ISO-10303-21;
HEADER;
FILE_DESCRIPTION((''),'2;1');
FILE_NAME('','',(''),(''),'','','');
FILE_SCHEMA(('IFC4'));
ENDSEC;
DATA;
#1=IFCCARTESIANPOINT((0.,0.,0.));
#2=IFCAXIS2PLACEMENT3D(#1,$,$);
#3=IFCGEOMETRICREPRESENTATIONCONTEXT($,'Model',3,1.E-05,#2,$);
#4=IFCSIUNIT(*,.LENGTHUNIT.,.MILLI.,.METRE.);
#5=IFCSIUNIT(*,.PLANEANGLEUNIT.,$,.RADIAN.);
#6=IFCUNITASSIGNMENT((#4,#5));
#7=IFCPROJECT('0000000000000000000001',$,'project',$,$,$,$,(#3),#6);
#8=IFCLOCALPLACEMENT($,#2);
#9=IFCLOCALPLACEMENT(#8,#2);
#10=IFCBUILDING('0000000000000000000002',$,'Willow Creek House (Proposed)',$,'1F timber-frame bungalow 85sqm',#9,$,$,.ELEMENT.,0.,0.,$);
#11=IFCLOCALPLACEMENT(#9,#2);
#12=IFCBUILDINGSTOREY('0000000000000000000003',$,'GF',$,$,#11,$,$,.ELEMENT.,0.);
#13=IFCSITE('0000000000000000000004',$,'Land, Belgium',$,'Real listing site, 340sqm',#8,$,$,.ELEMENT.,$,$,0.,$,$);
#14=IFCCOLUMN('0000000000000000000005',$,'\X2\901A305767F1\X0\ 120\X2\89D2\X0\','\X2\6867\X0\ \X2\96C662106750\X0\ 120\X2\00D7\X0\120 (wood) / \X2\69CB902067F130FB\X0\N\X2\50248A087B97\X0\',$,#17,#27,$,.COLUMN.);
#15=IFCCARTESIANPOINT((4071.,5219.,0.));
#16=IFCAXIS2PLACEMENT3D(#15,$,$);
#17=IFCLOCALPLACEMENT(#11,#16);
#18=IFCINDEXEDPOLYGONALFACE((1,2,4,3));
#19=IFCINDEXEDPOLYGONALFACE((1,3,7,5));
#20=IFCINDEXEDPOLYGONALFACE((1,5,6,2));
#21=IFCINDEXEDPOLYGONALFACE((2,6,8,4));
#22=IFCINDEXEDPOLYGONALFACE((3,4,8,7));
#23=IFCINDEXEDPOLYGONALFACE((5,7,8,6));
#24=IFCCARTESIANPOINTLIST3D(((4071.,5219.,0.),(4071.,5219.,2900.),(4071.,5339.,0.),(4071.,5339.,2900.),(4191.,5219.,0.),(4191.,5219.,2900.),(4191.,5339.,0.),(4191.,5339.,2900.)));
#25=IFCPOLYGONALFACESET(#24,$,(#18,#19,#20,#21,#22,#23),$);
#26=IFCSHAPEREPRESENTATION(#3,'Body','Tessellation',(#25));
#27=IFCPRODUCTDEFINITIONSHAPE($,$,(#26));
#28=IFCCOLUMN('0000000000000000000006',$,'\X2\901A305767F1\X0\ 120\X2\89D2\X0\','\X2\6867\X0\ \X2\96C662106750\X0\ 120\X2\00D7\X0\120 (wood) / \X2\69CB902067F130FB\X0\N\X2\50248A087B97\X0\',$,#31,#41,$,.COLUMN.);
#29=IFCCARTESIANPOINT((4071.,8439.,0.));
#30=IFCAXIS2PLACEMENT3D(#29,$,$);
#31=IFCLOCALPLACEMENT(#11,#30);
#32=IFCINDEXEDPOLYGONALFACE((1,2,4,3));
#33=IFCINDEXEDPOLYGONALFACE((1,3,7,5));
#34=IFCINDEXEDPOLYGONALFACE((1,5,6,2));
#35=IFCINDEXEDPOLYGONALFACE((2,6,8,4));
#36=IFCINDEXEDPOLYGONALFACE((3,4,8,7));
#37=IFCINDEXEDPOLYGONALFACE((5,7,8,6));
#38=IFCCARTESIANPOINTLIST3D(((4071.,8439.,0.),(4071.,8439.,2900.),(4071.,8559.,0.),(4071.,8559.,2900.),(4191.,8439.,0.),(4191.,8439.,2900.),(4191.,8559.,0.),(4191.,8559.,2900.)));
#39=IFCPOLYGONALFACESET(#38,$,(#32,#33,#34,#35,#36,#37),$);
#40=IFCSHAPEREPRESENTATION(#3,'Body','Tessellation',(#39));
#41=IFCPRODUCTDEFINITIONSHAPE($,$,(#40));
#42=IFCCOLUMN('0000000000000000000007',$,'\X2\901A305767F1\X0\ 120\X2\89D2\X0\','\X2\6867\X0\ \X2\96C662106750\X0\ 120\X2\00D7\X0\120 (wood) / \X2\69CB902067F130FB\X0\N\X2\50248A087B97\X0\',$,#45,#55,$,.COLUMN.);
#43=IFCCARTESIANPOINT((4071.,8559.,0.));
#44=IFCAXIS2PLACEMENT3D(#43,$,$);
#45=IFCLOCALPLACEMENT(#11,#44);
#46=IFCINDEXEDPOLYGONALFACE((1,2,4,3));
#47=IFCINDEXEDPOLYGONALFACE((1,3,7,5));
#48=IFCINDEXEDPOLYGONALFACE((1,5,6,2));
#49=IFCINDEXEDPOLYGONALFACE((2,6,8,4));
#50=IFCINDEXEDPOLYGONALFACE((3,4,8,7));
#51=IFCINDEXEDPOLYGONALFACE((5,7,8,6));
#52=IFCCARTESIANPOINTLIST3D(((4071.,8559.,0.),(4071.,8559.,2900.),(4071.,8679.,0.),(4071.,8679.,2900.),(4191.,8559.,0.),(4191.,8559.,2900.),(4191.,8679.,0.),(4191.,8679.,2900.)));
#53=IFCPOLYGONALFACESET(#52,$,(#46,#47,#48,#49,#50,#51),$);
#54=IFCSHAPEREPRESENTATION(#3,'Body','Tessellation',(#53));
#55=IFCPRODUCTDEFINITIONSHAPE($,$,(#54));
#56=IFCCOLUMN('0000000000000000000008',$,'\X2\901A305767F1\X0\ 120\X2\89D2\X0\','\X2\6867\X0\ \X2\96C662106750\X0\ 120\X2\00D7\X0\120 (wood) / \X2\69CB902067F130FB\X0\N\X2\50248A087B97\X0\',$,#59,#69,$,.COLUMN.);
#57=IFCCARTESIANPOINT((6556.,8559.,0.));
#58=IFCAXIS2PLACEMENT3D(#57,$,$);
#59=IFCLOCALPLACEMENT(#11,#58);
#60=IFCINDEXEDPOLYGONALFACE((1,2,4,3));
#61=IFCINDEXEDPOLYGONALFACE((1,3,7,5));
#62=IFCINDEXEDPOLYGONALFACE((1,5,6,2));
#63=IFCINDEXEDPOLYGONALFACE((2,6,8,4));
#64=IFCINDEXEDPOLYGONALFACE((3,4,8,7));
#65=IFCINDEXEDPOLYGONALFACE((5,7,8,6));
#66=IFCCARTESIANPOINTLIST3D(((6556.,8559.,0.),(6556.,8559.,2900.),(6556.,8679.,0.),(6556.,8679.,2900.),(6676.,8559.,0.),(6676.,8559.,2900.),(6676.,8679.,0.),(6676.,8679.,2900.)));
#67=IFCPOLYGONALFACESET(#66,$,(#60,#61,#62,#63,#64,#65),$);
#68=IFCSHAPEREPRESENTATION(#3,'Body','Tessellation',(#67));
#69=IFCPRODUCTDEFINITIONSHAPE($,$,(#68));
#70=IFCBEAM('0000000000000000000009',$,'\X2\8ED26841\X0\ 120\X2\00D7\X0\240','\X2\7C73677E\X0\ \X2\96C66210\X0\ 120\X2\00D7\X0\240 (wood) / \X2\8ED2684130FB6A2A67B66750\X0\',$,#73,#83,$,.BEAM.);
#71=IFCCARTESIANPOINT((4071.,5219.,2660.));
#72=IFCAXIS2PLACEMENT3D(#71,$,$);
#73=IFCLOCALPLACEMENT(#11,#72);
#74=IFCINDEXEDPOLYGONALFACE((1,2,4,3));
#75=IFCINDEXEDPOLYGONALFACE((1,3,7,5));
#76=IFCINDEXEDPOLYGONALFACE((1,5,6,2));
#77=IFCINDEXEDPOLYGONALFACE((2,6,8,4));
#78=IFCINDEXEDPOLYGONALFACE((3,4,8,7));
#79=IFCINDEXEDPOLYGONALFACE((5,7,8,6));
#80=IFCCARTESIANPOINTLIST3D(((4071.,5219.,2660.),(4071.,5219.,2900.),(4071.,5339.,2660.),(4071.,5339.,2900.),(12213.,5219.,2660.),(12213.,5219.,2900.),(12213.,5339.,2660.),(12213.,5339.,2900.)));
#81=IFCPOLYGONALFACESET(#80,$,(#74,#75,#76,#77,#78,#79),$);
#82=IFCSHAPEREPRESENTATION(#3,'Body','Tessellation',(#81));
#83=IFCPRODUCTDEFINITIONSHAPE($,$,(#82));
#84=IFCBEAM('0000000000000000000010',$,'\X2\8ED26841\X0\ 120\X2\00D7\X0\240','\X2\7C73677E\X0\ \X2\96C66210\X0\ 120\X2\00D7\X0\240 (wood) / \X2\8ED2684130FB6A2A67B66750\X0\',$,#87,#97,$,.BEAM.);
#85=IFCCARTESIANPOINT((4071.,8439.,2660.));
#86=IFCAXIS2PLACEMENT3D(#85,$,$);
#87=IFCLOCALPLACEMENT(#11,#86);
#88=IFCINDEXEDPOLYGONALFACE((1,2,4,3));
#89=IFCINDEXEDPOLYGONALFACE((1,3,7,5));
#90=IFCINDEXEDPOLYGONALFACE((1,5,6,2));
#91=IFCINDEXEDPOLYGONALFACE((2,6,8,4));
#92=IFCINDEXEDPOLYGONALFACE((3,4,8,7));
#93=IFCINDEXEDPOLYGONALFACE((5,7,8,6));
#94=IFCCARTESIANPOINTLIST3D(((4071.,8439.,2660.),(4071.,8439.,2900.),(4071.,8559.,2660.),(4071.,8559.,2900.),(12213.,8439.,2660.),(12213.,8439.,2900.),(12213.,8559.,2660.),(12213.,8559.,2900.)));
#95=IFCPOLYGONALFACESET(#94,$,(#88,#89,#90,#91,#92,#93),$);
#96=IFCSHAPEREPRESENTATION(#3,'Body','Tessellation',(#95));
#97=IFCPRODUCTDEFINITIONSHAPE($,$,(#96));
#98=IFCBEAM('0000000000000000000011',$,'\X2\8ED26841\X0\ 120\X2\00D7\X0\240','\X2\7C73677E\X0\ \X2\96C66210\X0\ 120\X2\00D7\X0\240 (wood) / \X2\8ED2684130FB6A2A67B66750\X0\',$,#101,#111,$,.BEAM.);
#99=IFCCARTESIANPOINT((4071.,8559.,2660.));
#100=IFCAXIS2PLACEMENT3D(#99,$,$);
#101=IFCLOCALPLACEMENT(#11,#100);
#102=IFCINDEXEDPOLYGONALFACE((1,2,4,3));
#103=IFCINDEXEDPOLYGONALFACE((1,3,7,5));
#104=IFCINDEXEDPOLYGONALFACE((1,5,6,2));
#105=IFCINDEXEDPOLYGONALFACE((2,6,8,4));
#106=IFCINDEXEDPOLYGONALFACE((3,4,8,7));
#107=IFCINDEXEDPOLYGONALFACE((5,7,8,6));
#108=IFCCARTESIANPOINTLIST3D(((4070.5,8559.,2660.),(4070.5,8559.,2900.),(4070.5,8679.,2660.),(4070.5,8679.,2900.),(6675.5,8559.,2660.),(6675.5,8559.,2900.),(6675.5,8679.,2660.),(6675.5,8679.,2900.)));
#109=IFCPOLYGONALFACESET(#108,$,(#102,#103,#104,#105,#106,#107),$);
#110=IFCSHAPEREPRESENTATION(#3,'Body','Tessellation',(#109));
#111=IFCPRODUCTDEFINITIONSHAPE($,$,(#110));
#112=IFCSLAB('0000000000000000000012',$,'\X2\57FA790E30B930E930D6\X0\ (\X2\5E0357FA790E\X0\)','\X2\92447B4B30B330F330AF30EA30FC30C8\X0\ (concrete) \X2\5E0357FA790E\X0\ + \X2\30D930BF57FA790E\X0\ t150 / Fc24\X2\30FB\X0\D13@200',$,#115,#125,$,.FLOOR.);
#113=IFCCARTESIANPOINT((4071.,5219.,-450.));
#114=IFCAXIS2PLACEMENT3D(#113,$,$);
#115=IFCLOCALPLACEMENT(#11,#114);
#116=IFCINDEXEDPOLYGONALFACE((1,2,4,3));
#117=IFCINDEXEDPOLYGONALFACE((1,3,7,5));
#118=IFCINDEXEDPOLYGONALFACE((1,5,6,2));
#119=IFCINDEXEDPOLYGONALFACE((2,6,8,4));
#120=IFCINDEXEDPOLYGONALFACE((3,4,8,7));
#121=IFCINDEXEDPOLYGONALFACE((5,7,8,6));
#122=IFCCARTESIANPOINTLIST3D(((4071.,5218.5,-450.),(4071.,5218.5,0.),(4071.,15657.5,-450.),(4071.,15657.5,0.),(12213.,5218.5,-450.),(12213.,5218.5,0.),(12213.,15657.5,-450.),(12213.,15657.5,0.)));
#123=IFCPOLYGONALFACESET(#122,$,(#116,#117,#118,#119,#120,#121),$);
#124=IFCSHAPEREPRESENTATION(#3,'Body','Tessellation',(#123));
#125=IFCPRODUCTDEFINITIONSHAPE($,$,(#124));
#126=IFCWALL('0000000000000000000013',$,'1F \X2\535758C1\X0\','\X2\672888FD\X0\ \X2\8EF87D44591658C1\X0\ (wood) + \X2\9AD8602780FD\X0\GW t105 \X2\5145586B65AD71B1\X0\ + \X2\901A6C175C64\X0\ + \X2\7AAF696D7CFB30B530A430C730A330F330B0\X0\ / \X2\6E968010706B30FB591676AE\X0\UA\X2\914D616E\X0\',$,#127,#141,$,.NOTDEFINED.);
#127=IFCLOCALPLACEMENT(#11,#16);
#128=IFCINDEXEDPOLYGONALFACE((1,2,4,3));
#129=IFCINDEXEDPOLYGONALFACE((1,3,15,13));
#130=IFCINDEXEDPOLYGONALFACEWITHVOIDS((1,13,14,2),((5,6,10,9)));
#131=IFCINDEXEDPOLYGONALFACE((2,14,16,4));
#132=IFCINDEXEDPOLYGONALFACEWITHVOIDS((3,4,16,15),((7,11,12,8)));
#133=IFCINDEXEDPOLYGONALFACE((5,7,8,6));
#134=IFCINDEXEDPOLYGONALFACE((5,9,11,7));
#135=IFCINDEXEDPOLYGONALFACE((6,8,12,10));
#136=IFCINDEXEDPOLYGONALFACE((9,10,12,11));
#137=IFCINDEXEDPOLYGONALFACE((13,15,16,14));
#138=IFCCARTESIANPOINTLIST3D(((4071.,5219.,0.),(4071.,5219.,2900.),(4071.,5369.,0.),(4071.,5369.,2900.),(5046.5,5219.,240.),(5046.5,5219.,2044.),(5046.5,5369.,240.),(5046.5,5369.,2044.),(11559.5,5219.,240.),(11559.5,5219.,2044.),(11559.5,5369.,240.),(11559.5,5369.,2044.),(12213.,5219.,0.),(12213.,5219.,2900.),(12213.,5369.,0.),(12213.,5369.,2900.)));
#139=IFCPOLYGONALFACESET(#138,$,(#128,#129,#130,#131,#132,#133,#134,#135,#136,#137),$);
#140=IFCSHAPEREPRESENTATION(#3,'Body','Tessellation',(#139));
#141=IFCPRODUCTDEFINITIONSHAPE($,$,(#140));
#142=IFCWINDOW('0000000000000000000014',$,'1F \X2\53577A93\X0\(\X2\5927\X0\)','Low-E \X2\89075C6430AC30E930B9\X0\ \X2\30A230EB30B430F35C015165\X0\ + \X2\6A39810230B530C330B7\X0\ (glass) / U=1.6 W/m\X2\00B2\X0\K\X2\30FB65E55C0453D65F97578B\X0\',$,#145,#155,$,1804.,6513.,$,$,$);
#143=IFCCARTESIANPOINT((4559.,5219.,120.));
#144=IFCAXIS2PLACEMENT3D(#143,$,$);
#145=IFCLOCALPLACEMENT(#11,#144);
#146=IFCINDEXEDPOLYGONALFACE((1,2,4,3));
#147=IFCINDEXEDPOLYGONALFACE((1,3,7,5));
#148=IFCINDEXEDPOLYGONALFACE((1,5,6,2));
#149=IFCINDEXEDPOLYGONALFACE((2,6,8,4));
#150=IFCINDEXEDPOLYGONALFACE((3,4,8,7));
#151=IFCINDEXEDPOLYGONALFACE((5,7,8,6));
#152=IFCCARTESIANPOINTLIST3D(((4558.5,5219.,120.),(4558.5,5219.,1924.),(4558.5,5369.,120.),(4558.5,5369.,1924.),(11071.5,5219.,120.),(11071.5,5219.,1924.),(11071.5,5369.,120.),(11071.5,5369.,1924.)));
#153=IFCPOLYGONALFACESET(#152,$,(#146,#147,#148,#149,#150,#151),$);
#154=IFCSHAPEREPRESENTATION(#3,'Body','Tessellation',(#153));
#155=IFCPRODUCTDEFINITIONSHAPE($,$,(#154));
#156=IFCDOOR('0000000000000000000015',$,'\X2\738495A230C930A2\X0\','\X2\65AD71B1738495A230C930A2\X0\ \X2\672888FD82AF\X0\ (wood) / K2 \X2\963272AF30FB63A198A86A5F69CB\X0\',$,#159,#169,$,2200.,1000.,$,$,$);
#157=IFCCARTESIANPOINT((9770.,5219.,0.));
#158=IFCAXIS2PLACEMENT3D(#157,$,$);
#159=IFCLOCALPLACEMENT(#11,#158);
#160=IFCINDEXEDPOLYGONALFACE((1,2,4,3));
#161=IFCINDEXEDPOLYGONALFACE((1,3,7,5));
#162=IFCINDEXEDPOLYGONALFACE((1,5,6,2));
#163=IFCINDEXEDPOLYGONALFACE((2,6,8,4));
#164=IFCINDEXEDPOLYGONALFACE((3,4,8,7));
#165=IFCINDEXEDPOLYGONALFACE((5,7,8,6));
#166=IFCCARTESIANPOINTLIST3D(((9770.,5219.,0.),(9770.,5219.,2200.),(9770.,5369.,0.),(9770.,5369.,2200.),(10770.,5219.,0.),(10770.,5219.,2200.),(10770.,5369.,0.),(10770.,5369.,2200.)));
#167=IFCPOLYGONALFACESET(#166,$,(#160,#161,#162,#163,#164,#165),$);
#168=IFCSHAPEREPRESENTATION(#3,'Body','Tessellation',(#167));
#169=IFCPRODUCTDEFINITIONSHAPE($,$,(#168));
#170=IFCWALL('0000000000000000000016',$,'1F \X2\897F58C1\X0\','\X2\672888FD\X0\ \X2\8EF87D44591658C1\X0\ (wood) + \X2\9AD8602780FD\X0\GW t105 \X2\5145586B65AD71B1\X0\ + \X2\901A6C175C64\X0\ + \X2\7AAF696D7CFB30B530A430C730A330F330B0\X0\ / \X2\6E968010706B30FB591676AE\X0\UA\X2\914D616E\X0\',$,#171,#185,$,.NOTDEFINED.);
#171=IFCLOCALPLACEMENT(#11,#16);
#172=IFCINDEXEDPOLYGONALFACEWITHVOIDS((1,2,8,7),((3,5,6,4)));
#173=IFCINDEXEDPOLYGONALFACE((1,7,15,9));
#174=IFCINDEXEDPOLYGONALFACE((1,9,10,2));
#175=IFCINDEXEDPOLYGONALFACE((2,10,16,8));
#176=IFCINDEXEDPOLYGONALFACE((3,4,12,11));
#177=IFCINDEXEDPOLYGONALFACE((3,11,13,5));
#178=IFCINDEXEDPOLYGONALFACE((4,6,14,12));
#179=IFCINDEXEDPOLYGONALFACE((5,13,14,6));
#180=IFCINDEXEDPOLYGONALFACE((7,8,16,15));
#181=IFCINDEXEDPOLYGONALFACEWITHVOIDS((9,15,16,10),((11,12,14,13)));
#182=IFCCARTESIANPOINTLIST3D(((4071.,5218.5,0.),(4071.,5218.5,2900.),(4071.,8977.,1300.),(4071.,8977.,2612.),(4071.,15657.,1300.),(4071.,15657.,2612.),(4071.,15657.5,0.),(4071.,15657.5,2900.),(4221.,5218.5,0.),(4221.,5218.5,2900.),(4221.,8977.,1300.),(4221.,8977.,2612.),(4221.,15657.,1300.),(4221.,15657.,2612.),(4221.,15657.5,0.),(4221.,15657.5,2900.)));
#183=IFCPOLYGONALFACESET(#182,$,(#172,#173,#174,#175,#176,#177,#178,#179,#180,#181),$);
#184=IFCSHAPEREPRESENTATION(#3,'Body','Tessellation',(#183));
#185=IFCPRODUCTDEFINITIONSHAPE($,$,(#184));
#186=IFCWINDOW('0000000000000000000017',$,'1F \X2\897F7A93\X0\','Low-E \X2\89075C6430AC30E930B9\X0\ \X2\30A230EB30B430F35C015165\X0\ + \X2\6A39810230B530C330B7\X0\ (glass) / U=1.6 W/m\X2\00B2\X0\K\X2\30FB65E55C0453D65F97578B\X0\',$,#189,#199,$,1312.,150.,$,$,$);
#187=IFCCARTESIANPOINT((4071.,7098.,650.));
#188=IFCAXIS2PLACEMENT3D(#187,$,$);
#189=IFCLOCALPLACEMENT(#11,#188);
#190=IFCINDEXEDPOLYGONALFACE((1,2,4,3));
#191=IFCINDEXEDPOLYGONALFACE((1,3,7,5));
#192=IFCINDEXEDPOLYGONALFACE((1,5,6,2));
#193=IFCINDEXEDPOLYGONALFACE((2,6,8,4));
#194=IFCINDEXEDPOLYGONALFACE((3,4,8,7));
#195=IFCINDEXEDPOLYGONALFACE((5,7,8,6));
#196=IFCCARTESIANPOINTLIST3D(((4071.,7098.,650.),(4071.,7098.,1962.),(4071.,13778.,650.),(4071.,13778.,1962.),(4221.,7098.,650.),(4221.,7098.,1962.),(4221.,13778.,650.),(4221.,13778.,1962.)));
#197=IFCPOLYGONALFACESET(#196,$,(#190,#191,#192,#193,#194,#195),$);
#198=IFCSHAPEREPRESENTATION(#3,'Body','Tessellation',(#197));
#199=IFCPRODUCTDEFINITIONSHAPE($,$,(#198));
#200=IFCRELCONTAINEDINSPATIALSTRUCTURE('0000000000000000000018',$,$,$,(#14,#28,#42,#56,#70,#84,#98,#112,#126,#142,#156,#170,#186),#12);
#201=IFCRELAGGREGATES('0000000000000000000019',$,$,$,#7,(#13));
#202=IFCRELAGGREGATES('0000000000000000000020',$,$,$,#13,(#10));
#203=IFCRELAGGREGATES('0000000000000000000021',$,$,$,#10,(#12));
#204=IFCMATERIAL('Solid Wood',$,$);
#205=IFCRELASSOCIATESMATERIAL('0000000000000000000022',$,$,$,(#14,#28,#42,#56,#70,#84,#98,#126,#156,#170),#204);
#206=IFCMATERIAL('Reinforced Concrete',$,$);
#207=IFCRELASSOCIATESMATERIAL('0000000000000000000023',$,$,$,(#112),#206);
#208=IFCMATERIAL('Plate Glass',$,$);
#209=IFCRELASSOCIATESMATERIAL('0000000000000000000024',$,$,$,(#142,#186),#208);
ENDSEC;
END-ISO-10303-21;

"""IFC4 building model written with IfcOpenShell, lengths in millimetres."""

from ifc_helpers import new_model, si_unit, frame, frame_2d, origin, place, context, project, spatial, rectangle, extrude, material, element, fill, save


model = new_model("IFC4")

# Units and contexts
model_context = context("Model", 3, precision=1e-05, world=origin())
ifc_project = project(units=[si_unit("LENGTHUNIT", "METRE", prefix="MILLI"), si_unit("PLANEANGLEUNIT", "RADIAN")], contexts=[model_context])

# Site, building, storey
site_placement = place(None, origin())
site = spatial("IfcSite", under=ifc_project, at=site_placement, Name="Land, Belgium", ObjectType="Real listing site, 340sqm", CompositionType="ELEMENT", RefElevation=0.0)
building_placement = place(site_placement, origin())
building = spatial("IfcBuilding", under=site, at=building_placement, Name="Willow Creek House (Proposed)", ObjectType="1F timber-frame bungalow 85sqm", CompositionType="ELEMENT", ElevationOfRefHeight=0.0, ElevationOfTerrain=0.0)
storey_placement = place(building_placement, origin())
storey = spatial("IfcBuildingStorey", under=building, at=storey_placement, Name="GF", CompositionType="ELEMENT", Elevation=0.0)

# Columns
ifc_material_1 = material(Name="Solid Wood")
column_1_placement = place(storey_placement, frame((4071.0, 5219.0, 0.0)))
element("IfcColumn", 1, at=column_1_placement, inside=storey, material=ifc_material_1, Name="通し柱 120角", Description="桧 集成材 120×120 (wood) / 構造柱・N値計算", PredefinedType="COLUMN", context=model_context, shape_type="SweptSolid", body=[
    extrude(rectangle(XDim=120.0, YDim=120.0, at=frame_2d((60.0, 60.0))), frame((4071.0, 5219.0, 0.0)), (0.0, 0.0, 1.0), 2900.0),
])
column_2_placement = place(storey_placement, frame((4071.0, 8439.0, 0.0)))
element("IfcColumn", 2, at=column_2_placement, inside=storey, material=ifc_material_1, Name="通し柱 120角", Description="桧 集成材 120×120 (wood) / 構造柱・N値計算", PredefinedType="COLUMN", context=model_context, shape_type="SweptSolid", body=[
    extrude(rectangle(XDim=120.0, YDim=120.0, at=frame_2d((60.0, 60.0))), frame((4071.0, 8439.0, 0.0)), (0.0, 0.0, 1.0), 2900.0),
])
column_3_placement = place(storey_placement, frame((4071.0, 8559.0, 0.0)))
element("IfcColumn", 3, at=column_3_placement, inside=storey, material=ifc_material_1, Name="通し柱 120角", Description="桧 集成材 120×120 (wood) / 構造柱・N値計算", PredefinedType="COLUMN", context=model_context, shape_type="SweptSolid", body=[
    extrude(rectangle(XDim=120.0, YDim=120.0, at=frame_2d((60.0, 60.0))), frame((4071.0, 8559.0, 0.0)), (0.0, 0.0, 1.0), 2900.0),
])
column_4_placement = place(storey_placement, frame((6556.0, 8559.0, 0.0)))
element("IfcColumn", 4, at=column_4_placement, inside=storey, material=ifc_material_1, Name="通し柱 120角", Description="桧 集成材 120×120 (wood) / 構造柱・N値計算", PredefinedType="COLUMN", context=model_context, shape_type="SweptSolid", body=[
    extrude(rectangle(XDim=120.0, YDim=120.0, at=frame_2d((60.0, 60.0))), frame((6556.0, 8559.0, 0.0)), (0.0, 0.0, 1.0), 2900.0),
])

# Beams
beam_1_placement = place(storey_placement, frame((4071.0, 5219.0, 2660.0)))
element("IfcBeam", 5, at=beam_1_placement, inside=storey, material=ifc_material_1, Name="軒桁 120×240", Description="米松 集成 120×240 (wood) / 軒桁・横架材", PredefinedType="BEAM", context=model_context, shape_type="SweptSolid", body=[
    extrude(rectangle(XDim=8142.0, YDim=120.0, at=frame_2d((4071.0, 60.0))), frame((4071.0, 5219.0, 2660.0)), (0.0, 0.0, 1.0), 240.0),
])
beam_2_placement = place(storey_placement, frame((4071.0, 8439.0, 2660.0)))
element("IfcBeam", 6, at=beam_2_placement, inside=storey, material=ifc_material_1, Name="軒桁 120×240", Description="米松 集成 120×240 (wood) / 軒桁・横架材", PredefinedType="BEAM", context=model_context, shape_type="SweptSolid", body=[
    extrude(rectangle(XDim=8142.0, YDim=120.0, at=frame_2d((4071.0, 60.0))), frame((4071.0, 8439.0, 2660.0)), (0.0, 0.0, 1.0), 240.0),
])
beam_3_placement = place(storey_placement, frame((4071.0, 8559.0, 2660.0)))
element("IfcBeam", 7, at=beam_3_placement, inside=storey, material=ifc_material_1, Name="軒桁 120×240", Description="米松 集成 120×240 (wood) / 軒桁・横架材", PredefinedType="BEAM", context=model_context, shape_type="SweptSolid", body=[
    extrude(rectangle(XDim=2605.0, YDim=120.0, at=frame_2d((1302.0, 60.0))), frame((4071.0, 8559.0, 2660.0)), (0.0, 0.0, 1.0), 240.0),
])

# Slab
ifc_material_2 = material(Name="Reinforced Concrete")
slab_1_placement = place(storey_placement, frame((4071.0, 5219.0, -450.0)))
element("IfcSlab", 8, at=slab_1_placement, inside=storey, material=ifc_material_2, Name="基礎スラブ (布基礎)", Description="鉄筋コンクリート (concrete) 布基礎 + ベタ基礎 t150 / Fc24・D13@200", PredefinedType="FLOOR", context=model_context, shape_type="SweptSolid", body=[
    extrude(rectangle(XDim=8142.0, YDim=10439.0, at=frame_2d((4071.0, 5219.0))), frame((4071.0, 5219.0, -450.0)), (0.0, 0.0, 1.0), 450.0),
])

# Wall, openings, window, door
wall_1_placement = place(storey_placement, frame((4071.0, 5219.0, 0.0)))
wall_1 = element("IfcWall", 9, at=wall_1_placement, inside=storey, material=ifc_material_1, Name="1F 南壁", Description="木製 軸組外壁 (wood) + 高性能GW t105 充填断熱 + 通気層 + 窯業系サイディング / 準耐火・外皮UA配慮", PredefinedType="NOTDEFINED", context=model_context, shape_type="SweptSolid", body=[
    extrude(rectangle(XDim=8142.0, YDim=150.0, at=frame_2d((4071.0, 75.0))), frame((4071.0, 5219.0, 0.0)), (0.0, 0.0, 1.0), 2900.0),
])
opening_1_placement = place(storey_placement, frame((4559.0, 5219.0, 120.0)))
opening_1 = element("IfcOpeningElement", 10, at=opening_1_placement, cuts=wall_1, PredefinedType="NOTDEFINED", context=model_context, shape_type="SweptSolid", body=[
    extrude(rectangle(XDim=6513.0, YDim=150.0, at=frame_2d((3256.0, 75.0))), frame((4559.0, 5219.0, 120.0)), (0.0, 0.0, 1.0), 1804.0),
])
opening_2_placement = place(storey_placement, frame((9770.0, 5219.0, 0.0)))
opening_2 = element("IfcOpeningElement", 11, at=opening_2_placement, cuts=wall_1, PredefinedType="NOTDEFINED", context=model_context, shape_type="SweptSolid", body=[
    extrude(rectangle(XDim=1000.0, YDim=150.0, at=frame_2d((500.0, 75.0))), frame((9770.0, 5219.0, 0.0)), (0.0, 0.0, 1.0), 2200.0),
])
ifc_material_3 = material(Name="Plate Glass")
window_1_placement = place(storey_placement, frame((4559.0, 5219.0, 120.0)))
window_1 = element("IfcWindow", 12, at=window_1_placement, inside=storey, material=ifc_material_3, Name="1F 南窓(大)", Description="Low-E 複層ガラス アルゴン封入 + 樹脂サッシ (glass) / U=1.6 W/m²K・日射取得型", OverallHeight=1804.0, OverallWidth=6513.0, context=model_context, shape_type="SweptSolid", body=[
    extrude(rectangle(XDim=6513.0, YDim=150.0, at=frame_2d((3256.0, 75.0))), frame((4559.0, 5219.0, 120.0)), (0.0, 0.0, 1.0), 1804.0),
])
fill(opening_1, window_1)
door_placement = place(storey_placement, frame((9770.0, 5219.0, 0.0)))
door = element("IfcDoor", 13, at=door_placement, inside=storey, material=ifc_material_1, Name="玄関ドア", Description="断熱玄関ドア 木製芯 (wood) / K2 防犯・採風機構", OverallHeight=2200.0, OverallWidth=1000.0, context=model_context, shape_type="SweptSolid", body=[
    extrude(rectangle(XDim=1000.0, YDim=150.0, at=frame_2d((500.0, 75.0))), frame((9770.0, 5219.0, 0.0)), (0.0, 0.0, 1.0), 2200.0),
])
fill(opening_2, door)

# Wall, opening, window
wall_2_placement = place(storey_placement, frame((4071.0, 5219.0, 0.0)))
wall_2 = element("IfcWall", 14, at=wall_2_placement, inside=storey, material=ifc_material_1, Name="1F 西壁", Description="木製 軸組外壁 (wood) + 高性能GW t105 充填断熱 + 通気層 + 窯業系サイディング / 準耐火・外皮UA配慮", PredefinedType="NOTDEFINED", context=model_context, shape_type="SweptSolid", body=[
    extrude(rectangle(XDim=150.0, YDim=10439.0, at=frame_2d((75.0, 5219.0))), frame((4071.0, 5219.0, 0.0)), (0.0, 0.0, 1.0), 2900.0),
])
opening_3_placement = place(storey_placement, frame((4071.0, 7098.0, 650.0)))
opening_3 = element("IfcOpeningElement", 15, at=opening_3_placement, cuts=wall_2, PredefinedType="NOTDEFINED", context=model_context, shape_type="SweptSolid", body=[
    extrude(rectangle(XDim=150.0, YDim=6680.0, at=frame_2d((75.0, 3340.0))), frame((4071.0, 7098.0, 650.0)), (0.0, 0.0, 1.0), 1312.0),
])
window_2_placement = place(storey_placement, frame((4071.0, 7098.0, 650.0)))
window_2 = element("IfcWindow", 16, at=window_2_placement, inside=storey, material=ifc_material_3, Name="1F 西窓", Description="Low-E 複層ガラス アルゴン封入 + 樹脂サッシ (glass) / U=1.6 W/m²K・日射取得型", OverallHeight=1312.0, OverallWidth=150.0, context=model_context, shape_type="SweptSolid", body=[
    extrude(rectangle(XDim=150.0, YDim=6680.0, at=frame_2d((75.0, 3340.0))), frame((4071.0, 7098.0, 650.0)), (0.0, 0.0, 1.0), 1312.0),
])
fill(opening_3, window_2)

save(model, "model.ifc")
